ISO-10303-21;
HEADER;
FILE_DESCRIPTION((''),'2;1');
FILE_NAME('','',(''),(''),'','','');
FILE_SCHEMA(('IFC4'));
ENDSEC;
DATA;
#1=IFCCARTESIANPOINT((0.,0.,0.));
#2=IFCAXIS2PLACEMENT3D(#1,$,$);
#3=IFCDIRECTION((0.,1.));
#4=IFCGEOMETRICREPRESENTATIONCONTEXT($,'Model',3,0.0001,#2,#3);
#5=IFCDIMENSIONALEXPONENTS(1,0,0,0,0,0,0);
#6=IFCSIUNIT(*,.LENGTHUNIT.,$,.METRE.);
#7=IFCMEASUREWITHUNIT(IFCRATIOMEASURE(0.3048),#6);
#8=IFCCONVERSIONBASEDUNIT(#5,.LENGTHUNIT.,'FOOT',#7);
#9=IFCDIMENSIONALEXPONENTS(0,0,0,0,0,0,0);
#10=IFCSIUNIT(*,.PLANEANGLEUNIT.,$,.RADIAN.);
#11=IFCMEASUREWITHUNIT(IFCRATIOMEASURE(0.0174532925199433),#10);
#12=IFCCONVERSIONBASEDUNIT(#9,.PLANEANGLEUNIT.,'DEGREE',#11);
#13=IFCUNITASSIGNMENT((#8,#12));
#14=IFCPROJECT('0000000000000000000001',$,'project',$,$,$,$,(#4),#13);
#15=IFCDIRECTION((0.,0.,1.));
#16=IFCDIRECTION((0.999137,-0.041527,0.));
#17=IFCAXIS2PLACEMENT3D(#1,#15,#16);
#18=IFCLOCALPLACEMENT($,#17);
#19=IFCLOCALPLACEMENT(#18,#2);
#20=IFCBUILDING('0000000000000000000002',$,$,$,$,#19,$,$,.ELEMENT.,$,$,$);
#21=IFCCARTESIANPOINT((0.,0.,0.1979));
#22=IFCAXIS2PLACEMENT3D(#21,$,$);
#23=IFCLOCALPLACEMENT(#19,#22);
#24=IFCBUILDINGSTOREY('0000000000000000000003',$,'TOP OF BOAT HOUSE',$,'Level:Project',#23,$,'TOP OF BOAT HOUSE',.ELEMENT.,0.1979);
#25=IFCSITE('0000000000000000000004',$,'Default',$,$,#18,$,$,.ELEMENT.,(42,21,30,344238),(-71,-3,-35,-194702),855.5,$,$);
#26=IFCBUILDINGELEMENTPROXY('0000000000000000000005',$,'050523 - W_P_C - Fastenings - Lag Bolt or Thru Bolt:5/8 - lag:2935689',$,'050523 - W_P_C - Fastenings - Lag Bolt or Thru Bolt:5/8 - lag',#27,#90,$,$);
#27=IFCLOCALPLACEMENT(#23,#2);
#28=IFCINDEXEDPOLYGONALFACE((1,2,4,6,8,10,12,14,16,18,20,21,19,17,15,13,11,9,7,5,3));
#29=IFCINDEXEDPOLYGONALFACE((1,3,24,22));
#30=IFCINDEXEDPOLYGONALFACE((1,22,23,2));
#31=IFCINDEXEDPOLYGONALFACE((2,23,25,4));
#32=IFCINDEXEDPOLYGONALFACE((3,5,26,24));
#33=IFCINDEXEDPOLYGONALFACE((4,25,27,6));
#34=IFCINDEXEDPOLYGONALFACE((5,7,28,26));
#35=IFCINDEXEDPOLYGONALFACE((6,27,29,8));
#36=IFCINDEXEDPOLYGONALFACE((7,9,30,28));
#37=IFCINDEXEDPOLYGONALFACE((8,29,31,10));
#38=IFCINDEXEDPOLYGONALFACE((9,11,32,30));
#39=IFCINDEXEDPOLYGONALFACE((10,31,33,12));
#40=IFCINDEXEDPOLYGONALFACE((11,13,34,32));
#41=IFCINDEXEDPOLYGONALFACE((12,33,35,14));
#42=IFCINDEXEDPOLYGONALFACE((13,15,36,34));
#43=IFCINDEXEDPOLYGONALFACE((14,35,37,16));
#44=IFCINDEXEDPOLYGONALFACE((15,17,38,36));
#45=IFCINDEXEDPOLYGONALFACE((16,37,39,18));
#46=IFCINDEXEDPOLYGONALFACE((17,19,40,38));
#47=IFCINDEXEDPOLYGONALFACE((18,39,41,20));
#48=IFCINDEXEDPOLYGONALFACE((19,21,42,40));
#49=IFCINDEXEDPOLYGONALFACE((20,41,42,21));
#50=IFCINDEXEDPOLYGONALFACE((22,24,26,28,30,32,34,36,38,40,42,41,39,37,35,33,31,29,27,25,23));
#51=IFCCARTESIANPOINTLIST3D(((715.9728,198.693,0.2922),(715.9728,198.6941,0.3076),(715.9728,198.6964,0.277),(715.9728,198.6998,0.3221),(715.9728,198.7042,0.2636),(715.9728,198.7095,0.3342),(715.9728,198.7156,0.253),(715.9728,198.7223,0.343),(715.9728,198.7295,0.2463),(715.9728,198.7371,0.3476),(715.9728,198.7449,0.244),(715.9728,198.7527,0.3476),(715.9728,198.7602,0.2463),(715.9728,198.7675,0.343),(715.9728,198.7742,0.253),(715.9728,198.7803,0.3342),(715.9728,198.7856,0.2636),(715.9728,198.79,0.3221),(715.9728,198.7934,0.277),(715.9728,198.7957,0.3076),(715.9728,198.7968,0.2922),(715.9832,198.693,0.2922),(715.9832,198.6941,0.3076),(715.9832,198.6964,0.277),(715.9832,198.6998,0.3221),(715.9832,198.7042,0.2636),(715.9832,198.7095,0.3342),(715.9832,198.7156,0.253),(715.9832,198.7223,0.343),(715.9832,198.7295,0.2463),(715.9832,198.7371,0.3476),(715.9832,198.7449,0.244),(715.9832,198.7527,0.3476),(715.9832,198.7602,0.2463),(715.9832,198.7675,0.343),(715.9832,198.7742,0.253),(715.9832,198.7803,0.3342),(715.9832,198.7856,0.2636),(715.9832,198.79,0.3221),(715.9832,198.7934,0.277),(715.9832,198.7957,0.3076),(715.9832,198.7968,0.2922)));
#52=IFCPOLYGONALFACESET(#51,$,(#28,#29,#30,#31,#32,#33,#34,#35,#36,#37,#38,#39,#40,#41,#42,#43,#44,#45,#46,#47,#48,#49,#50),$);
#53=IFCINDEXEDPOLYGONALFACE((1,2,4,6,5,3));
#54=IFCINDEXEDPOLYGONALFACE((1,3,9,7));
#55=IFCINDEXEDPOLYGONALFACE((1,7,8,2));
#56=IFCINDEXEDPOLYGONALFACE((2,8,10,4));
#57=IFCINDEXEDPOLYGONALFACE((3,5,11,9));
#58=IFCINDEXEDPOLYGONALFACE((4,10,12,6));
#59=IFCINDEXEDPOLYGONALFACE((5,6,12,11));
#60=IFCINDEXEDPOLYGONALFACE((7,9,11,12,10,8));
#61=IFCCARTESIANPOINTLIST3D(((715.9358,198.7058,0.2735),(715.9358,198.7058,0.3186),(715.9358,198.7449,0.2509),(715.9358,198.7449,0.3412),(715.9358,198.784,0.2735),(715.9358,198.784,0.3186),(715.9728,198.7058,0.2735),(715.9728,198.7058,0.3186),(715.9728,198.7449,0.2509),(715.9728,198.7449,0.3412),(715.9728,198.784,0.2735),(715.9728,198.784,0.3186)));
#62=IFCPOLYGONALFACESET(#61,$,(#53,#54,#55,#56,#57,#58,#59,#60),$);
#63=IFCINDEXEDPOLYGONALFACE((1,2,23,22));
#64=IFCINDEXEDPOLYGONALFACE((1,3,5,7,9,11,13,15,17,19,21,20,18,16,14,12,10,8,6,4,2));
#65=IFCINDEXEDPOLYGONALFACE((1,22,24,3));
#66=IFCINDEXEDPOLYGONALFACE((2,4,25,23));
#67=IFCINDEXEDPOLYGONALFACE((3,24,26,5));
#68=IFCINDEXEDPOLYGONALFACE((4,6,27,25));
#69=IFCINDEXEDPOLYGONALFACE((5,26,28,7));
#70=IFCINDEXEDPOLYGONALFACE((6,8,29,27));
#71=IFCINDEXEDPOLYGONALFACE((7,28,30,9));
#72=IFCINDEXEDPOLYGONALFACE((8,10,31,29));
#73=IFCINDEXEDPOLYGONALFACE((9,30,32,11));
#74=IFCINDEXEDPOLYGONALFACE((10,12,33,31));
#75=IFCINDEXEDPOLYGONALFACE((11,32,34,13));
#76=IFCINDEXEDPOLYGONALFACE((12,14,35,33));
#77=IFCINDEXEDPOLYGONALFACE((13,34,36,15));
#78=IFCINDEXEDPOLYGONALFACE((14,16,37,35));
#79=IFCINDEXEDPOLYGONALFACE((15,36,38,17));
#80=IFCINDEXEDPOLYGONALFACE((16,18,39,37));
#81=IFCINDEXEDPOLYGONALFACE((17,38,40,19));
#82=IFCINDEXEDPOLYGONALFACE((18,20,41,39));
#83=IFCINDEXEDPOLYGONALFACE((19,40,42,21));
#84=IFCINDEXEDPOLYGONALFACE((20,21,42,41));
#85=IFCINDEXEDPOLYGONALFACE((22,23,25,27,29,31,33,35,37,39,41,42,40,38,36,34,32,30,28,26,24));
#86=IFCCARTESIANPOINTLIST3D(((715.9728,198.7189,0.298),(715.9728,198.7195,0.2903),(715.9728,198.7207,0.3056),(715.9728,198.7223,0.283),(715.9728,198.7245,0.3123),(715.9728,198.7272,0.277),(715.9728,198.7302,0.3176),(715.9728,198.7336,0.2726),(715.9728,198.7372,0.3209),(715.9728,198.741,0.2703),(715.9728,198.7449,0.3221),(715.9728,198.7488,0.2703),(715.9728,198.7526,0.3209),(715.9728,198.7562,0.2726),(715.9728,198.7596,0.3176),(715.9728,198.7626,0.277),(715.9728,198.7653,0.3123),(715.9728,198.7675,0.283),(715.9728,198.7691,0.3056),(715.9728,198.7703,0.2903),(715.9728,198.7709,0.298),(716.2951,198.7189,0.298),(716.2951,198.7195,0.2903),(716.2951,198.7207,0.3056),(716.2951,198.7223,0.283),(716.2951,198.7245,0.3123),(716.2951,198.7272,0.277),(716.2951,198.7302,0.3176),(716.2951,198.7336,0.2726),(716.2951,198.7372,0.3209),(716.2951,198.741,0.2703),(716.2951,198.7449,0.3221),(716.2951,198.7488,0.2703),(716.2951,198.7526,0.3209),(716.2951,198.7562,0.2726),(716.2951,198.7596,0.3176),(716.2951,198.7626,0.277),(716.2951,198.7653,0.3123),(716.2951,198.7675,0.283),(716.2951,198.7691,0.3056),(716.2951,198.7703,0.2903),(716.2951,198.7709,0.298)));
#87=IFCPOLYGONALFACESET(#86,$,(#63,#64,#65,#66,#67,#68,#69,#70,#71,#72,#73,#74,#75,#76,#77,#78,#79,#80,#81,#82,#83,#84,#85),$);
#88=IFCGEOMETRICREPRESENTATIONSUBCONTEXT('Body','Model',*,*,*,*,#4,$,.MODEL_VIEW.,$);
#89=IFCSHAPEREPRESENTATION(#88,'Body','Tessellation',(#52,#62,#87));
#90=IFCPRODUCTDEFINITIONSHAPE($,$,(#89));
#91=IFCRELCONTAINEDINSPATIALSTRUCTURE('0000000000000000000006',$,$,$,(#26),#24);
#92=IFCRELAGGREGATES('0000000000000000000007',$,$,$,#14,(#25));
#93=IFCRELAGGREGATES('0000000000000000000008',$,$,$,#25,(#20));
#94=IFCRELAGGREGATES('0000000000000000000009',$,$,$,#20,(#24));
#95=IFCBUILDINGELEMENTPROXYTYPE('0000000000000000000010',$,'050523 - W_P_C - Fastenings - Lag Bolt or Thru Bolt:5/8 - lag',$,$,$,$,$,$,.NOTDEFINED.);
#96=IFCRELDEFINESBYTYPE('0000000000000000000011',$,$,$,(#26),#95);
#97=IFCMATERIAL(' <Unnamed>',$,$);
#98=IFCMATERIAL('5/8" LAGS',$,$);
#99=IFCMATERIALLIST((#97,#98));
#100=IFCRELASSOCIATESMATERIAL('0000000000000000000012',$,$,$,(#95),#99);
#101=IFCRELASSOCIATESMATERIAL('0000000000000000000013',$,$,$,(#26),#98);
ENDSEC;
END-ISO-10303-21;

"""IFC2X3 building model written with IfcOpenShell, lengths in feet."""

from ifc_helpers import new_model, entity, si_unit, converted_unit, direction, frame, frame_2d, origin, place, context, subcontext, project, spatial, polyline, circle, outline, extrude, source, transform, mapped, material, material_list, type_object, type_shapes, element, save


model = new_model("IFC2X3")

# Units and contexts
model_context = context("Model", 3, precision=0.0001, world=origin(), true_north=direction((0.0, 1.0)))
body_context = subcontext(model_context, "Body", "Model", "MODEL_VIEW")
ifc_project = project(units=[converted_unit("LENGTHUNIT", "FOOT", entity("IfcRatioMeasure", 0.3048), si_unit("LENGTHUNIT", "METRE"), dimensions=[1, 0, 0, 0, 0, 0, 0]), converted_unit("PLANEANGLEUNIT", "DEGREE", entity("IfcRatioMeasure", 0.0174532925199433), si_unit("PLANEANGLEUNIT", "RADIAN"), dimensions=[0, 0, 0, 0, 0, 0, 0])], contexts=[model_context])

# Site, building, storey
site_placement = place(None, frame((0.0, 0.0, 0.0), z_axis=(0.0, 0.0, 1.0), x_axis=(0.999137, -0.041527, 0.0)))
site = spatial("IfcSite", under=ifc_project, at=site_placement, Name="Default", CompositionType="ELEMENT", RefLatitude=(42, 21, 30, 344238), RefLongitude=(-71, -3, -35, -194702), RefElevation=855.5)
building_placement = place(site_placement, origin())
building = spatial("IfcBuilding", under=site, at=building_placement, CompositionType="ELEMENT")
storey_placement = place(building_placement, frame((0.0, 0.0, 0.1979)))
storey = spatial("IfcBuildingStorey", under=building, at=storey_placement, Name="TOP OF BOAT HOUSE", ObjectType="Level:Project", LongName="TOP OF BOAT HOUSE", CompositionType="ELEMENT", Elevation=0.1979)

# Building element proxy
ifc_material_1 = material(Name=" <Unnamed>")
ifc_material_2 = material(Name="5/8\" LAGS")
ifc_material_list_1 = material_list([ifc_material_1, ifc_material_2])
building_element_proxy_type_1 = type_object("IfcBuildingElementProxyType", Name="050523 - W_P_C - Fastenings - Lag Bolt or Thru Bolt:5/8 - lag", PredefinedType="NOTDEFINED", material=ifc_material_list_1)
shared_shape_1 = source(origin(), body_context, "Body", "SweptSolid", [
    extrude(circle(Radius=0.0521, at=frame_2d((0.0, 0.0), x_axis=(1.0, 0.0))), frame((0.0, 0.0, 0.0), z_axis=(0.0, 0.0, 1.0), x_axis=(0.0, -1.0, 0.0)), (0.0, 0.0, 1.0), 0.0104),
    extrude(outline(polyline([(-0.0226, -0.0391), (0.0226, -0.0391), (0.0451, 0.0), (0.0226, 0.0391), (-0.0226, 0.0391), (-0.0451, 0.0), (-0.0226, -0.0391)])), frame((0.0, 0.0, 0.0104), z_axis=(0.0, 0.0, 1.0), x_axis=(0.0, -1.0, 0.0)), (0.0, 0.0, 1.0), 0.037),
    extrude(circle(Radius=0.026, at=frame_2d((0.0, 0.0), x_axis=(1.0, 0.0))), frame((0.0, 0.0, -0.312), z_axis=(0.0, 0.0, 1.0), x_axis=(0.0, 1.0, 0.0)), (0.0, 0.0, 1.0), 0.3224),
])
type_shapes(building_element_proxy_type_1, [shared_shape_1])
for number, where, z_axis, x_axis, name in (
    (1, (715.9832, 198.7449, 0.2961), (-1.0, 0.0, 0.0), (0.0, -1.0, 0.0), "050523 - W_P_C - Fastenings - Lag Bolt or Thru Bolt:5/8 - lag:2935689"),
):
    element("IfcBuildingElementProxy", number, at=place(storey_placement, frame(where, z_axis=z_axis, x_axis=x_axis)), inside=storey, type_object=building_element_proxy_type_1, material=ifc_material_2, Name=name, ObjectType="050523 - W_P_C - Fastenings - Lag Bolt or Thru Bolt:5/8 - lag", context=body_context, shape_type="MappedRepresentation", body=[
        mapped(shared_shape_1, transform((0.0, 0.0, 0.0), scale=1.0)),
    ])

save(model, "model.ifc")
